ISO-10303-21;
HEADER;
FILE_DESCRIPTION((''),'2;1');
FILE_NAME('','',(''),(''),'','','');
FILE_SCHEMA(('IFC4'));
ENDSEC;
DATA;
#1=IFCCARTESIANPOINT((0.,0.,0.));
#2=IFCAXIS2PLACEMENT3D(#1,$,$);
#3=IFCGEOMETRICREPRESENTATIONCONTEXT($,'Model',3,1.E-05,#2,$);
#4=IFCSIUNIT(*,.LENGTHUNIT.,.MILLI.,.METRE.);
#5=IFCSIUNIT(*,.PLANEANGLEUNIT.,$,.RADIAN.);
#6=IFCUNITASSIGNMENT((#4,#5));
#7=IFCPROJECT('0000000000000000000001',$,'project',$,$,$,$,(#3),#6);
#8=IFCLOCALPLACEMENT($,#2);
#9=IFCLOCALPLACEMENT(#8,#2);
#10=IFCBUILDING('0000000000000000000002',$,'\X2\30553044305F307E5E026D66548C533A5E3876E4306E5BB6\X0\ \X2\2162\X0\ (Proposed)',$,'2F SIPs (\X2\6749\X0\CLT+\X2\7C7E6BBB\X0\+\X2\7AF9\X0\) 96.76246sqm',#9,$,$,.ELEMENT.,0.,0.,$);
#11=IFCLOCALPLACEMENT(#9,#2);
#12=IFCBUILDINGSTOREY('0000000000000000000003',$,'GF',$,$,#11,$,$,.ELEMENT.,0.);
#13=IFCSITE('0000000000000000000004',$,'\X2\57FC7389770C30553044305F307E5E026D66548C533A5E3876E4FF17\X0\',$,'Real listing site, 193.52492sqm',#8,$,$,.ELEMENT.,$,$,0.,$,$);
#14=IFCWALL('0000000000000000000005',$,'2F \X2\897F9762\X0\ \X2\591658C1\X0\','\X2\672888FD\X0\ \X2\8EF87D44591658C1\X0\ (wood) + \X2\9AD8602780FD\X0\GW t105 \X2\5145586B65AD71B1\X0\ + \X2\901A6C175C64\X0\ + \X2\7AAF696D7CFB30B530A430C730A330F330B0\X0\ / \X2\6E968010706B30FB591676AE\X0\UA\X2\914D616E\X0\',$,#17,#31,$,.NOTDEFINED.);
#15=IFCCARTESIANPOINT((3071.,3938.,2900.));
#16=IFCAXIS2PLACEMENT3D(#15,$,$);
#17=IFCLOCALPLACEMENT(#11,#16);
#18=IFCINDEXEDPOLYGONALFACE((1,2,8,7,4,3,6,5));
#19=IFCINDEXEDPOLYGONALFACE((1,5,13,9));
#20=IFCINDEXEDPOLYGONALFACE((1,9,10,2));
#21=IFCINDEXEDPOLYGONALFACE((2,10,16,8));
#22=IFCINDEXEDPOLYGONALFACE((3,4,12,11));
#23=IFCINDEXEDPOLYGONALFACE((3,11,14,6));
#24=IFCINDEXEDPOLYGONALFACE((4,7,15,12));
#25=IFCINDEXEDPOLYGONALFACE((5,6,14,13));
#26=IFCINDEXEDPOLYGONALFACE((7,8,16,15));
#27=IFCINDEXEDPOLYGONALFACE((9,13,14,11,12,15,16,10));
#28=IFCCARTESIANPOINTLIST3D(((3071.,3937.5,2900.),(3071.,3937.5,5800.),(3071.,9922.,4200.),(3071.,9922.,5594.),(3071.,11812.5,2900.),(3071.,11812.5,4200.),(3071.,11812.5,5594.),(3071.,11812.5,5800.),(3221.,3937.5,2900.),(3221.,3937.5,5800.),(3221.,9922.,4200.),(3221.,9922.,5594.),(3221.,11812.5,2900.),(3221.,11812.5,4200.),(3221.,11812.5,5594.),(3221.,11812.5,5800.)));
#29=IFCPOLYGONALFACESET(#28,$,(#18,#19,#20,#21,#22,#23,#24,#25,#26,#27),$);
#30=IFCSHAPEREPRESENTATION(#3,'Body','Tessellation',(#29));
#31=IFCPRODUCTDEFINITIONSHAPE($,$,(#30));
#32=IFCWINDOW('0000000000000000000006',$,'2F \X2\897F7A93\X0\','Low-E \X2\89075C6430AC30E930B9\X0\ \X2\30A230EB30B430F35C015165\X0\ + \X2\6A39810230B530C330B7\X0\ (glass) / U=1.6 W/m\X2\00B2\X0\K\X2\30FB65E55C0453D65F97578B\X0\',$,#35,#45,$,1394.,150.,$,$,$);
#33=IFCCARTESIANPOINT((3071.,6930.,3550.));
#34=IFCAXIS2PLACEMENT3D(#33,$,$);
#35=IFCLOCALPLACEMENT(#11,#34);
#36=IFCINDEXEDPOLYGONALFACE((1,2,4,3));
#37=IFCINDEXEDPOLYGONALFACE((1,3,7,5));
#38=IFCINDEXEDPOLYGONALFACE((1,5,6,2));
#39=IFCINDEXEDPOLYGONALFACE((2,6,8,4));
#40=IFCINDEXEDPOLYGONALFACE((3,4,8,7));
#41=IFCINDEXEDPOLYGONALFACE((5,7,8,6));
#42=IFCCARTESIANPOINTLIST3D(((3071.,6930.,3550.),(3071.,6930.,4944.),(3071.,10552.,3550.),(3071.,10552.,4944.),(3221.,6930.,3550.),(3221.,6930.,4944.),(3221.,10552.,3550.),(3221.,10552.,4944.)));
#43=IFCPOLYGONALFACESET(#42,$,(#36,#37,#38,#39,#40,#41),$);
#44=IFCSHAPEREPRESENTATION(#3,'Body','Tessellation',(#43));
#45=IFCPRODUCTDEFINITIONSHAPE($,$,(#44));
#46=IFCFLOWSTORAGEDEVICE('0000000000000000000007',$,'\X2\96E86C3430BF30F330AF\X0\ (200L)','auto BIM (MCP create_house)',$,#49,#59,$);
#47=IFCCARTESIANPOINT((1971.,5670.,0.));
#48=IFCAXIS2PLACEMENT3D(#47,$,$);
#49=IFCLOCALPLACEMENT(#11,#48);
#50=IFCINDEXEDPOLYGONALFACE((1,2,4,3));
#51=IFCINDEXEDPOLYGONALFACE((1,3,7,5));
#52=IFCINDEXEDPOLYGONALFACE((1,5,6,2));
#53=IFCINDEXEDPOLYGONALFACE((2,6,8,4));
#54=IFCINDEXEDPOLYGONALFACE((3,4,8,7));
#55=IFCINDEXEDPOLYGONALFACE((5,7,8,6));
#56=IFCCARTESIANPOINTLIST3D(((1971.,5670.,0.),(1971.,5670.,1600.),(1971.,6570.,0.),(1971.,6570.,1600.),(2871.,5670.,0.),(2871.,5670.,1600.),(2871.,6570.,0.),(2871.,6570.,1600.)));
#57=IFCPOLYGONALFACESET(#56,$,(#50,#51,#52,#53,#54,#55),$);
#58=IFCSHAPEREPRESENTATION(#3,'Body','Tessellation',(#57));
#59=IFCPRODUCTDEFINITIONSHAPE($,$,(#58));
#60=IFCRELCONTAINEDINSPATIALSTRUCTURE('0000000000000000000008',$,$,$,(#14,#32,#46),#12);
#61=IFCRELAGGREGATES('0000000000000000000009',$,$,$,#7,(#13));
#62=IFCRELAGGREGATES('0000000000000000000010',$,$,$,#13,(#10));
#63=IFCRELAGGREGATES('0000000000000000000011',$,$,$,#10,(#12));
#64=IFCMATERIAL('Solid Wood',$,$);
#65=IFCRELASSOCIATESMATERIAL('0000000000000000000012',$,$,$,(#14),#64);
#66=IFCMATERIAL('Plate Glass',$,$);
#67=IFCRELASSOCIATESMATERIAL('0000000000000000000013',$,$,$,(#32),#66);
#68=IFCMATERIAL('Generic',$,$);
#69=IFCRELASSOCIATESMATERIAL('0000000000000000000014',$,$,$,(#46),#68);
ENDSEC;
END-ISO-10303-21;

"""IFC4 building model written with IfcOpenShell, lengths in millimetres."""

from ifc_helpers import new_model, si_unit, frame, frame_2d, origin, place, context, project, spatial, rectangle, extrude, material, element, fill, save


model = new_model("IFC4")

# Units and contexts
model_context = context("Model", 3, precision=1e-05, world=origin())
ifc_project = project(units=[si_unit("LENGTHUNIT", "METRE", prefix="MILLI"), si_unit("PLANEANGLEUNIT", "RADIAN")], contexts=[model_context])

# Site, building, storey
site_placement = place(None, origin())
site = spatial("IfcSite", under=ifc_project, at=site_placement, Name="埼玉県さいたま市浦和区常盤７", ObjectType="Real listing site, 193.52492sqm", CompositionType="ELEMENT", RefElevation=0.0)
building_placement = place(site_placement, origin())
building = spatial("IfcBuilding", under=site, at=building_placement, Name="さいたま市浦和区常盤の家 Ⅲ (Proposed)", ObjectType="2F SIPs (杉CLT+籾殻+竹) 96.76246sqm", CompositionType="ELEMENT", ElevationOfRefHeight=0.0, ElevationOfTerrain=0.0)
storey_placement = place(building_placement, origin())
storey = spatial("IfcBuildingStorey", under=building, at=storey_placement, Name="GF", CompositionType="ELEMENT", Elevation=0.0)

# Shared definitions
ifc_material_1 = material(Name="Solid Wood")

# Shared definitions
ifc_material_2 = material(Name="Plate Glass")

# Wall, opening, window
wall_1_placement = place(storey_placement, frame((3071.0, 3938.0, 2900.0)))
wall_1 = element("IfcWall", 1, at=wall_1_placement, inside=storey, material=ifc_material_1, Name="2F 西面 外壁", Description="木製 軸組外壁 (wood) + 高性能GW t105 充填断熱 + 通気層 + 窯業系サイディング / 準耐火・外皮UA配慮", PredefinedType="NOTDEFINED", context=model_context, shape_type="SweptSolid", body=[
    extrude(rectangle(XDim=150.0, YDim=7875.0, at=frame_2d((75.0, 3937.0))), frame((3071.0, 3938.0, 2900.0)), (0.0, 0.0, 1.0), 2900.0),
])
opening_1_placement = place(storey_placement, frame((3071.0, 6930.0, 3550.0)))
opening_1 = element("IfcOpeningElement", 2, at=opening_1_placement, cuts=wall_1, PredefinedType="NOTDEFINED", context=model_context, shape_type="SweptSolid", body=[
    extrude(rectangle(XDim=150.0, YDim=3622.0, at=frame_2d((75.0, 1811.0))), frame((3071.0, 6930.0, 3550.0)), (0.0, 0.0, 1.0), 1394.0),
])
window_1_placement = place(storey_placement, frame((3071.0, 6930.0, 3550.0)))
window_1 = element("IfcWindow", 3, at=window_1_placement, inside=storey, material=ifc_material_2, Name="2F 西窓", Description="Low-E 複層ガラス アルゴン封入 + 樹脂サッシ (glass) / U=1.6 W/m²K・日射取得型", OverallHeight=1394.0, OverallWidth=150.0, context=model_context, shape_type="SweptSolid", body=[
    extrude(rectangle(XDim=150.0, YDim=3622.0, at=frame_2d((75.0, 1811.0))), frame((3071.0, 6930.0, 3550.0)), (0.0, 0.0, 1.0), 1394.0),
])
fill(opening_1, window_1)

# Shared definitions
ifc_material_3 = material(Name="Generic")

# Flow storage device
flow_storage_device_placement = place(storey_placement, frame((1971.0, 5670.0, 0.0)))
element("IfcFlowStorageDevice", 4, at=flow_storage_device_placement, inside=storey, material=ifc_material_3, Name="雨水タンク (200L)", Description="auto BIM (MCP create_house)", context=model_context, shape_type="SweptSolid", body=[
    extrude(rectangle(XDim=900.0, YDim=900.0, at=frame_2d((450.0, 450.0))), frame((1971.0, 5670.0, 0.0)), (0.0, 0.0, 1.0), 1600.0),
])

save(model, "model.ifc")
